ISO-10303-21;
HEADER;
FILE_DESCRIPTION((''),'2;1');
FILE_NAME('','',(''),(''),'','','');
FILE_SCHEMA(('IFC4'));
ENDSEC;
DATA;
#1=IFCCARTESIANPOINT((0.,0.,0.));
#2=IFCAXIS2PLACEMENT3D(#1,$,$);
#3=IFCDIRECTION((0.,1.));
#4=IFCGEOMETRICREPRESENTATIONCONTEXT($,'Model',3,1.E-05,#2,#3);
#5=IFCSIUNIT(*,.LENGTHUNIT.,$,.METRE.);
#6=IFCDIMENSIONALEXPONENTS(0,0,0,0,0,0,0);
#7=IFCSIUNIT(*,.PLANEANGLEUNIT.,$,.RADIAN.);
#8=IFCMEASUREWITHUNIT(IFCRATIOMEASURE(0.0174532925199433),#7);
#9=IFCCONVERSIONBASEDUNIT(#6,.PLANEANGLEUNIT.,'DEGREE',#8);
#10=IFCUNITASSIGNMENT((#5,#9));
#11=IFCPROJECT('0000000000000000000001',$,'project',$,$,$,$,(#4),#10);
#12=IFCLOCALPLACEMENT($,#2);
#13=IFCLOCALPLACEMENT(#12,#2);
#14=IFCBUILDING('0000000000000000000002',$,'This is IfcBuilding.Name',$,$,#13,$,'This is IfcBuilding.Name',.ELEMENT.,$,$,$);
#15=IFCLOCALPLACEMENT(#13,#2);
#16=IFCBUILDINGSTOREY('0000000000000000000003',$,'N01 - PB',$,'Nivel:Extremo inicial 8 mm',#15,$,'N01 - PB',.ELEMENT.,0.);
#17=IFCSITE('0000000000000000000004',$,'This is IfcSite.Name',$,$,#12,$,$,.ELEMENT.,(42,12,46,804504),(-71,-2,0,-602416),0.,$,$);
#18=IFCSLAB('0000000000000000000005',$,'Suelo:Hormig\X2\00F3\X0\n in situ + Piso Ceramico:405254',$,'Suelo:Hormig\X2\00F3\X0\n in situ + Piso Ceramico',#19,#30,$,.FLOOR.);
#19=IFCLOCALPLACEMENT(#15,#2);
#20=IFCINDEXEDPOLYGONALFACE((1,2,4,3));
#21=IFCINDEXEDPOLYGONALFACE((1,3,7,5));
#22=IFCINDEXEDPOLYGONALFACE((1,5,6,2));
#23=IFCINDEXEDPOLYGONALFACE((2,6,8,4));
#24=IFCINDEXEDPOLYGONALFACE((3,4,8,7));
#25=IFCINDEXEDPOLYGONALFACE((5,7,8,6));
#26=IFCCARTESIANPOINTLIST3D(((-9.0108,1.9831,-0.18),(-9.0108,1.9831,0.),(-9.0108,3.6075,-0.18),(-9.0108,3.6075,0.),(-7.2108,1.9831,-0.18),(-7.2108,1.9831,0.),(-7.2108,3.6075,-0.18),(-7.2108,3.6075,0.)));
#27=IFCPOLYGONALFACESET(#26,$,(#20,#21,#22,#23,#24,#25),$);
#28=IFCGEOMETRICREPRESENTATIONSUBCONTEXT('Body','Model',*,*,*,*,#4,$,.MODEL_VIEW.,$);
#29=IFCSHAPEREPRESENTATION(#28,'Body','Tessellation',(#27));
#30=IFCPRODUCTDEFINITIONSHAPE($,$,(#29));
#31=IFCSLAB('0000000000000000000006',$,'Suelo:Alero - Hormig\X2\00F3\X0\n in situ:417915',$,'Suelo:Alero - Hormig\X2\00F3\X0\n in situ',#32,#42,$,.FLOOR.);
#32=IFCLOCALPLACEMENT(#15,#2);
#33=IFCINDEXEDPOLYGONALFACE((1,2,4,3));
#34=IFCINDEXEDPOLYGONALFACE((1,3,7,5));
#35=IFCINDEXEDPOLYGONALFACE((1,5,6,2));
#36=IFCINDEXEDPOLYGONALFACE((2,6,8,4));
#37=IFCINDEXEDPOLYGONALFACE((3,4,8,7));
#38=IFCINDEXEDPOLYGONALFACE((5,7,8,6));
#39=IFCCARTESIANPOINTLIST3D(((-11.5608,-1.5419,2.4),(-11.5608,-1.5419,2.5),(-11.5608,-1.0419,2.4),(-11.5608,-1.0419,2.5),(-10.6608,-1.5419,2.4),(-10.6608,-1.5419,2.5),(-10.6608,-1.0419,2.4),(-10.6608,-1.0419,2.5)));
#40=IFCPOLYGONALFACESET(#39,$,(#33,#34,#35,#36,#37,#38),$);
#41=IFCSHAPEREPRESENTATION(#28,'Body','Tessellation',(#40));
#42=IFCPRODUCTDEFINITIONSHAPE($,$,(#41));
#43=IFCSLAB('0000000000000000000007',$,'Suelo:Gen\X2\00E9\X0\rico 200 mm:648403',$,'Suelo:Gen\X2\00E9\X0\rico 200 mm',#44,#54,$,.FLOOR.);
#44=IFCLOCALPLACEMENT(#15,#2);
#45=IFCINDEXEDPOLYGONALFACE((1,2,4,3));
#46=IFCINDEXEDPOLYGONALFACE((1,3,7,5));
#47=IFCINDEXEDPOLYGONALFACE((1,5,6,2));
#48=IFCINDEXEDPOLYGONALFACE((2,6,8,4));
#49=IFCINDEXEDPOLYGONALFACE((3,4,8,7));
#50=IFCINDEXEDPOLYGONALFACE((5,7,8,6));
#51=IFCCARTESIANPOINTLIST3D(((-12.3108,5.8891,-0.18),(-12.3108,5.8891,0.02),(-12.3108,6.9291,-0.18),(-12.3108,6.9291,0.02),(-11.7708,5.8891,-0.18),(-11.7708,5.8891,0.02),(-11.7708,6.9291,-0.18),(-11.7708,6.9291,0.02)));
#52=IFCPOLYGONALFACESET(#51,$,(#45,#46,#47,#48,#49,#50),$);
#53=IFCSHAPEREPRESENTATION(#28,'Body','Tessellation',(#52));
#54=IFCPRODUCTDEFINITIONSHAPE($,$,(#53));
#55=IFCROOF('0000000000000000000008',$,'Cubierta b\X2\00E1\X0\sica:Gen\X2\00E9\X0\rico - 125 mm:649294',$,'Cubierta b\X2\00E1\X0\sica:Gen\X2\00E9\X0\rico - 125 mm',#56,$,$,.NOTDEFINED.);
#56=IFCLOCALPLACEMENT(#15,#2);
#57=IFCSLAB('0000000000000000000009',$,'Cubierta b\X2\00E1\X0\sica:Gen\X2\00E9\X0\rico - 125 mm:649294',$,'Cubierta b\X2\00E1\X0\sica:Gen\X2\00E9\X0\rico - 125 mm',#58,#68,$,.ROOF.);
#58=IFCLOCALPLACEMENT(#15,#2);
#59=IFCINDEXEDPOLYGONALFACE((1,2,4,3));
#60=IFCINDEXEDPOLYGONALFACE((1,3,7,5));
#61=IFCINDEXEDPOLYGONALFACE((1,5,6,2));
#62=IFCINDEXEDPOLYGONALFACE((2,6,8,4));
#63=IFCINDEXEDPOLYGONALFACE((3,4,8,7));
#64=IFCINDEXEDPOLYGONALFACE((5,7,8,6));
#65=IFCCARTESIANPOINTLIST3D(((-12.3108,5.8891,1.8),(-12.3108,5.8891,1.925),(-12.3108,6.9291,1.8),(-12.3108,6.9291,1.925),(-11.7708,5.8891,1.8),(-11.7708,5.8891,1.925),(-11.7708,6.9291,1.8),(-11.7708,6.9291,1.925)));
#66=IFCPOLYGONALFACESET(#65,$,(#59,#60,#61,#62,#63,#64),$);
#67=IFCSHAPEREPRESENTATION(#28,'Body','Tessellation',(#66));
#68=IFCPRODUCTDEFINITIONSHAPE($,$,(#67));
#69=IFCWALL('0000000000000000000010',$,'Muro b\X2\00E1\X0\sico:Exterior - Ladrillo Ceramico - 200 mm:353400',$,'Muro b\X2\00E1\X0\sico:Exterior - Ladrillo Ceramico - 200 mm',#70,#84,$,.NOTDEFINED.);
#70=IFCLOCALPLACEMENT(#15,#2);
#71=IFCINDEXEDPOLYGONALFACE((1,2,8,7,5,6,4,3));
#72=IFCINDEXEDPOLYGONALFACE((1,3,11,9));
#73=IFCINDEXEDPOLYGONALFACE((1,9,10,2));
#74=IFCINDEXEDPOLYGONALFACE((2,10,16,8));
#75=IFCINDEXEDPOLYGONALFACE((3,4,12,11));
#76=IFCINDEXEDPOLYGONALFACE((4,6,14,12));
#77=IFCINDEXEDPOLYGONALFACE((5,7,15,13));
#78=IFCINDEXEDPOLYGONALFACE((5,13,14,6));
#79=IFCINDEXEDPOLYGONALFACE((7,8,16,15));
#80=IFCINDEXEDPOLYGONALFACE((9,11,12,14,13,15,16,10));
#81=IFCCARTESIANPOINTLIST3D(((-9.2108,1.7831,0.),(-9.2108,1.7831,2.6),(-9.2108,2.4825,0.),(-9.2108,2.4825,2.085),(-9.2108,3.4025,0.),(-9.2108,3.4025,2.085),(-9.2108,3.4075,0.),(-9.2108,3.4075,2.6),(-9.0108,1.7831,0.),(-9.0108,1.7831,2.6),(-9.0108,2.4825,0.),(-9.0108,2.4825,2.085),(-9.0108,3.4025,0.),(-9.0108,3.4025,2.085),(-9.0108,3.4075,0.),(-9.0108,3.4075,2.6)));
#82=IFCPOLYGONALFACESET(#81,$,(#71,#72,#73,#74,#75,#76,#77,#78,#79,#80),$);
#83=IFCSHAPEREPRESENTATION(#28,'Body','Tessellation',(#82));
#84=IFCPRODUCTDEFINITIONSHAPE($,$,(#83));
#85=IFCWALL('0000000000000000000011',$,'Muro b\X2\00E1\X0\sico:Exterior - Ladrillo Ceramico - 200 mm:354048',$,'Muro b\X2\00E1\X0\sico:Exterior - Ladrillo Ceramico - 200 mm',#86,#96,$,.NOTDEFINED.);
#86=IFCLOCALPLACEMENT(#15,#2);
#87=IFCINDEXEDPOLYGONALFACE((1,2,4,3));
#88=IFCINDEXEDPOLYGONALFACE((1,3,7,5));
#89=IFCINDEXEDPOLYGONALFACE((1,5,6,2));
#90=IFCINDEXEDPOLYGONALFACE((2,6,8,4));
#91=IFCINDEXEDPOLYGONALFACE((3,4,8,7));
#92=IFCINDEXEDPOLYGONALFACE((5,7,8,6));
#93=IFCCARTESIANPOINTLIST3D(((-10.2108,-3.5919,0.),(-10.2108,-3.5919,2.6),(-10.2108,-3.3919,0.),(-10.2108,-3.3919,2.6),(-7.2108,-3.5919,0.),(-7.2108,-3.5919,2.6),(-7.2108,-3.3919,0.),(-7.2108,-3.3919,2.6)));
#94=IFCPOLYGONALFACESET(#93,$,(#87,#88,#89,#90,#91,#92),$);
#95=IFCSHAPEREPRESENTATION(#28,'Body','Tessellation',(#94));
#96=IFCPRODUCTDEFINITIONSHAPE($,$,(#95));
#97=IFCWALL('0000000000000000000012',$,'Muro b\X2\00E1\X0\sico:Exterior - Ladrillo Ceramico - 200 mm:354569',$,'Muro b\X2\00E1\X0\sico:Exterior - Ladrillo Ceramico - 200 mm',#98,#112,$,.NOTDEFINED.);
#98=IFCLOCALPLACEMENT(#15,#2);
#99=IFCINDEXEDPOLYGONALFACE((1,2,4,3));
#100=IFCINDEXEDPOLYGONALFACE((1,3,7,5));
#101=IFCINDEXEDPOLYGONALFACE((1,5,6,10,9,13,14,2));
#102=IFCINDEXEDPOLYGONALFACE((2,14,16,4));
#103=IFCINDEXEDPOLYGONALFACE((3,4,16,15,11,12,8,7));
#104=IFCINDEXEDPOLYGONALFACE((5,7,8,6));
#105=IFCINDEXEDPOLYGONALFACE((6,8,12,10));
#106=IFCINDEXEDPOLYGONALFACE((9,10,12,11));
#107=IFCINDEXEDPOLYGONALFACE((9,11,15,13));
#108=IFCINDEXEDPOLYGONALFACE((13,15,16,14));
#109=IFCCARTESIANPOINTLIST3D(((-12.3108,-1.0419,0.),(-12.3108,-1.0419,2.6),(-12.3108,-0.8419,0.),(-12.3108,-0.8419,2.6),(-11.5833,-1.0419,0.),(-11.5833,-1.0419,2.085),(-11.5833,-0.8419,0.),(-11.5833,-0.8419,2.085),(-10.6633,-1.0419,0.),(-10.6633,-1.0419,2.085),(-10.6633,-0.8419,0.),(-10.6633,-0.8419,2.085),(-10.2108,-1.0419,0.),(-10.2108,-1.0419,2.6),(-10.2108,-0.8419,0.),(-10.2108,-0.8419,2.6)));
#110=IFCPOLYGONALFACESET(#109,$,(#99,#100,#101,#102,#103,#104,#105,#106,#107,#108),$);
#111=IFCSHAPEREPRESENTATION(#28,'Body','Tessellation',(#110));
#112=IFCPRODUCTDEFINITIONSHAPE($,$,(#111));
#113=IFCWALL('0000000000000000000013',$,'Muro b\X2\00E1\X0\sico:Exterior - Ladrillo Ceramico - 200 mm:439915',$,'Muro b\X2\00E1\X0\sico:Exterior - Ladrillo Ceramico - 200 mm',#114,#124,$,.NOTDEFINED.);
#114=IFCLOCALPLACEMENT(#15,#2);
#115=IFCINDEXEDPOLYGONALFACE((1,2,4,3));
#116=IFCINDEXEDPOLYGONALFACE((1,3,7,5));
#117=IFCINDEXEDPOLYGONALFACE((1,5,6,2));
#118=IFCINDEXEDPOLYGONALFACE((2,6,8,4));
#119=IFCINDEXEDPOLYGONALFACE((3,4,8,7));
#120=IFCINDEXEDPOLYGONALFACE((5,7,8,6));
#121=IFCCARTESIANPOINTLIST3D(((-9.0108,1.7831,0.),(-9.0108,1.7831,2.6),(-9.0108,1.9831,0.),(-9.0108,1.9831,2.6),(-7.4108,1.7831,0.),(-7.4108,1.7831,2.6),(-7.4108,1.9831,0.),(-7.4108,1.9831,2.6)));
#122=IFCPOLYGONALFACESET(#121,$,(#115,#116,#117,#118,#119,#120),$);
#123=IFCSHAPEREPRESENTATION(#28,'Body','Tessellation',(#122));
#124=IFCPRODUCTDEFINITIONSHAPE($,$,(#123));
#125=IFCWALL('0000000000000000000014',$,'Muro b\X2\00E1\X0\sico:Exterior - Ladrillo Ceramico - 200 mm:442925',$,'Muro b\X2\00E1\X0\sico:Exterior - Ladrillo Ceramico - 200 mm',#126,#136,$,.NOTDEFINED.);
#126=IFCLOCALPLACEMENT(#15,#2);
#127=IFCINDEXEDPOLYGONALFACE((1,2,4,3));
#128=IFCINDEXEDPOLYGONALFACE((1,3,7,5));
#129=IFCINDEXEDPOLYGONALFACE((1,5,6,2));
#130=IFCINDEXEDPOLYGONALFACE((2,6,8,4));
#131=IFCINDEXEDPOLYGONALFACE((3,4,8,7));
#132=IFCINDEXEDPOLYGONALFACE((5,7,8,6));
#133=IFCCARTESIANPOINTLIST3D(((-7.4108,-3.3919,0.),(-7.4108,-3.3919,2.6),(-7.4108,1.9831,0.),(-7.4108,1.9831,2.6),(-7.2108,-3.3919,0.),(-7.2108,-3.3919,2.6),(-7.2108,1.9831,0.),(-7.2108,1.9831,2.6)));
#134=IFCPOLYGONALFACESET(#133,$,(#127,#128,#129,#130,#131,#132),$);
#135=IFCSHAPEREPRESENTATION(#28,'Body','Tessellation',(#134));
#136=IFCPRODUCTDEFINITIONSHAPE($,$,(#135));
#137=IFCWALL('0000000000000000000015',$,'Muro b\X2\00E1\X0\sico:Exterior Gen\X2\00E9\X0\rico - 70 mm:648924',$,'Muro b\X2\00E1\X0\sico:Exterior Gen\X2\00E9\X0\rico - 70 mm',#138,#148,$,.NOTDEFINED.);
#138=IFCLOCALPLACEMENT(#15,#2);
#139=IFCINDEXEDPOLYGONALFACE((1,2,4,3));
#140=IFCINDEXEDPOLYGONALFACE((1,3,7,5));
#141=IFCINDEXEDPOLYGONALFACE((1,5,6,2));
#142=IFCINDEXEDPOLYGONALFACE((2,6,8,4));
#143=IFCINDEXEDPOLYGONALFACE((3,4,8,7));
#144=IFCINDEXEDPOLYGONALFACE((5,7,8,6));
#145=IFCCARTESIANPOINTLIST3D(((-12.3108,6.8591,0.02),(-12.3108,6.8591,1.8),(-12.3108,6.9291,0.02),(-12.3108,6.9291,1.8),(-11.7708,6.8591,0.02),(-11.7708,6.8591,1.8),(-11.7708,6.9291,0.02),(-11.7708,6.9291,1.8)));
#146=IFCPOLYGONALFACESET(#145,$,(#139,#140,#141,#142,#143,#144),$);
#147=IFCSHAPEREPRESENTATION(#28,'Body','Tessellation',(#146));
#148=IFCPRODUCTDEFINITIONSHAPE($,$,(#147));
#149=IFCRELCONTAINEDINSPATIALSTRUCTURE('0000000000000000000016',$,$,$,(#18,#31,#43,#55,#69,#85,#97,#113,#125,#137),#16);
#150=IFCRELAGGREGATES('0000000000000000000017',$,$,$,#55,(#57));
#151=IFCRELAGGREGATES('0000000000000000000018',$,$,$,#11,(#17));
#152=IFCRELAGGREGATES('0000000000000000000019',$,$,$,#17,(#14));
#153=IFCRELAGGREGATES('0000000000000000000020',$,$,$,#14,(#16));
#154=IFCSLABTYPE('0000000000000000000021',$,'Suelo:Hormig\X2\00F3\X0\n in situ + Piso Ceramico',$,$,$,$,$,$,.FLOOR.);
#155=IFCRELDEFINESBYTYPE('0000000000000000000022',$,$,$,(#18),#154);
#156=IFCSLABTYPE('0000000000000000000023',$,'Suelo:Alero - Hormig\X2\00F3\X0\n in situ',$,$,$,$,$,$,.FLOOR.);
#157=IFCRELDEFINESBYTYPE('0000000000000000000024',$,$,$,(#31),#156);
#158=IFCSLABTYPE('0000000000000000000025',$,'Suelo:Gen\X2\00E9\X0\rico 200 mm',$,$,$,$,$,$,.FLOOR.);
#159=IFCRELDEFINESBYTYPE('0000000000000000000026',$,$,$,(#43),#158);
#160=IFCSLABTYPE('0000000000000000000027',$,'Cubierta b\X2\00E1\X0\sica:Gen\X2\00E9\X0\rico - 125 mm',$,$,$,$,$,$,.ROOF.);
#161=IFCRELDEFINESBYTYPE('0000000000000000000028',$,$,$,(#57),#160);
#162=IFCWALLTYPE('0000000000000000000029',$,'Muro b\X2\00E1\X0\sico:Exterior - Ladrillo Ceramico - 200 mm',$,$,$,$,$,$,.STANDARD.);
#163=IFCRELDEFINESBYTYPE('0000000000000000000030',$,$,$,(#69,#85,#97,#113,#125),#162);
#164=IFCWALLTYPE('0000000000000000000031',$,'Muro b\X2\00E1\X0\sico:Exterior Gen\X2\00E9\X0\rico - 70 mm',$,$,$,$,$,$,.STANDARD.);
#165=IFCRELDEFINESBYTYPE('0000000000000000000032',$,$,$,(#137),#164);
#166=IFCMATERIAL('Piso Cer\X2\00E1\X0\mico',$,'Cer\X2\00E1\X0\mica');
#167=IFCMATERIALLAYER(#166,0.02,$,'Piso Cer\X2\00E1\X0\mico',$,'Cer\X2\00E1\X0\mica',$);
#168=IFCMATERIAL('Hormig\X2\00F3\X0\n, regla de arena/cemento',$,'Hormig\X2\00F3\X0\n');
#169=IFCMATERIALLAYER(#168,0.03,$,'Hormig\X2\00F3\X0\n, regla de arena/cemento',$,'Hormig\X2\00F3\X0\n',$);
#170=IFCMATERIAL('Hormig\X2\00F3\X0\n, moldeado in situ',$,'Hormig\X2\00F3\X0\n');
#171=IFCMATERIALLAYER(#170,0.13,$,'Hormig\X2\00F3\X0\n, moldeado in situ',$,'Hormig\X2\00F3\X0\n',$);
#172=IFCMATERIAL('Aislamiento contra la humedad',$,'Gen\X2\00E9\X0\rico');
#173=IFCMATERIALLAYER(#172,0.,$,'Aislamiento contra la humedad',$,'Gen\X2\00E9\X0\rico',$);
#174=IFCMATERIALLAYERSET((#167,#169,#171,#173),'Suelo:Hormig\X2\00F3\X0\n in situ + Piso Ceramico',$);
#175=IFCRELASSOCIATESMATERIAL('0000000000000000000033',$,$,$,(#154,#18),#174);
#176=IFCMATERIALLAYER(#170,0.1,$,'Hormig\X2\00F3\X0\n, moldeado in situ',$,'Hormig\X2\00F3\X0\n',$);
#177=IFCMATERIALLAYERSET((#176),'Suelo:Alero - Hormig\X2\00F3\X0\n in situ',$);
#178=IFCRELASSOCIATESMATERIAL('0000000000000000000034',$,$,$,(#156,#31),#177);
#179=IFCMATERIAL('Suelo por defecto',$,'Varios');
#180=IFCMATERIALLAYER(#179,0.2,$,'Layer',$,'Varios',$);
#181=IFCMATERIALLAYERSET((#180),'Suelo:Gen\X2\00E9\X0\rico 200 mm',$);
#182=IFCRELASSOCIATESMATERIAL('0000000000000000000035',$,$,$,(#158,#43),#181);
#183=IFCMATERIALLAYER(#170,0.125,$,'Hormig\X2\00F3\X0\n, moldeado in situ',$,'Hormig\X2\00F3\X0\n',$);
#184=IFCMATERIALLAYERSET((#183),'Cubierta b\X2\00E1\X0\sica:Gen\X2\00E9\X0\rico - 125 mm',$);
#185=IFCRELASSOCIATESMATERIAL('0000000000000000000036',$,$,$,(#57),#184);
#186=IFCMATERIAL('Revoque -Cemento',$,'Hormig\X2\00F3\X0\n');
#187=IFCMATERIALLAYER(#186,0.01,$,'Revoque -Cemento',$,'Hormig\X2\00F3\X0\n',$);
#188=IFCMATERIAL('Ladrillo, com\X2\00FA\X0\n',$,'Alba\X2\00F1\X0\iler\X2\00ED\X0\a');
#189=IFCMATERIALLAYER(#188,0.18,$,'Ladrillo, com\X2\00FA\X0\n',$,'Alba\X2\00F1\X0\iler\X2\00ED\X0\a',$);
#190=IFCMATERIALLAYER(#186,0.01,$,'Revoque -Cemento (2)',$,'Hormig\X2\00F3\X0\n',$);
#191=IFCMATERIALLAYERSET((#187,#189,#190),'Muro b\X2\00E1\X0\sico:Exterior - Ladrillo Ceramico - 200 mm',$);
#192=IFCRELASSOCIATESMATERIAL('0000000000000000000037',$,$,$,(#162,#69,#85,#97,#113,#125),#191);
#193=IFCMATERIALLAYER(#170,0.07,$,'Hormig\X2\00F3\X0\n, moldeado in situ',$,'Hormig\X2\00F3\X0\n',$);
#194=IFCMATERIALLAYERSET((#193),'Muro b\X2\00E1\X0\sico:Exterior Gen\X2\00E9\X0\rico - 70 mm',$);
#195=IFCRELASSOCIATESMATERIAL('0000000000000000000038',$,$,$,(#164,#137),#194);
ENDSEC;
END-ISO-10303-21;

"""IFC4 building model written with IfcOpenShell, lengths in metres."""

from ifc_helpers import new_model, entity, si_unit, converted_unit, direction, frame, frame_2d, origin, origin_2d_with_axis, place, context, subcontext, project, spatial, polyline, rectangle, extrude, clip, bounded_halfspace, material, layer, layer_set, layer_usage, type_object, element, aggregate, save


model = new_model("IFC4")

# Units and contexts
model_context = context("Model", 3, precision=1e-05, world=origin(), true_north=direction((0.0, 1.0)))
body_context = subcontext(model_context, "Body", "Model", "MODEL_VIEW")
ifc_project = project(units=[si_unit("LENGTHUNIT", "METRE"), converted_unit("PLANEANGLEUNIT", "DEGREE", entity("IfcRatioMeasure", 0.0174532925199433), si_unit("PLANEANGLEUNIT", "RADIAN"), dimensions=[0, 0, 0, 0, 0, 0, 0])], contexts=[model_context])

# Site, building, storey
site_placement = place(None, origin())
site = spatial("IfcSite", under=ifc_project, at=site_placement, Name="This is IfcSite.Name", CompositionType="ELEMENT", RefLatitude=(42, 12, 46, 804504), RefLongitude=(-71, -2, 0, -602416), RefElevation=0.0)
building_placement = place(site_placement, origin())
building = spatial("IfcBuilding", under=site, at=building_placement, Name="This is IfcBuilding.Name", LongName="This is IfcBuilding.Name", CompositionType="ELEMENT")
storey_placement = place(building_placement, origin())
storey = spatial("IfcBuildingStorey", under=building, at=storey_placement, Name="N01 - PB", ObjectType="Nivel:Extremo inicial 8 mm", LongName="N01 - PB", CompositionType="ELEMENT", Elevation=0.0)

# Slabs
ifc_material_1 = material(Name="Piso Cerámico", Category="Cerámica")
ifc_layer_1 = layer(ifc_material_1, 0.02, Name="Piso Cerámico", Category="Cerámica")
ifc_material_2 = material(Name="Hormigón, regla de arena/cemento", Category="Hormigón")
ifc_layer_2 = layer(ifc_material_2, 0.03, Name="Hormigón, regla de arena/cemento", Category="Hormigón")
ifc_material_3 = material(Name="Hormigón, moldeado in situ", Category="Hormigón")
ifc_layer_3 = layer(ifc_material_3, 0.13, Name="Hormigón, moldeado in situ", Category="Hormigón")
ifc_material_4 = material(Name="Aislamiento contra la humedad", Category="Genérico")
ifc_layer_4 = layer(ifc_material_4, 0.0, Name="Aislamiento contra la humedad", Category="Genérico")
ifc_layer_set_1 = layer_set([ifc_layer_1, ifc_layer_2, ifc_layer_3, ifc_layer_4], Name="Suelo:Hormigón in situ + Piso Ceramico")
ifc_layer_usage_1 = layer_usage(ifc_layer_set_1, "AXIS3", "POSITIVE", 0.0)
slab_type_1 = type_object("IfcSlabType", Name="Suelo:Hormigón in situ + Piso Ceramico", PredefinedType="FLOOR", material=ifc_layer_set_1)
slab_1_placement = place(storey_placement, origin())
element("IfcSlab", 1, at=slab_1_placement, inside=storey, type_object=slab_type_1, material=ifc_layer_usage_1, Name="Suelo:Hormigón in situ + Piso Ceramico:405254", ObjectType="Suelo:Hormigón in situ + Piso Ceramico", PredefinedType="FLOOR", context=body_context, shape_type="SweptSolid", body=[
    extrude(rectangle(XDim=1.6243, YDim=1.8, at=origin_2d_with_axis()), frame((-8.1108, 2.7953, 0.0), z_axis=(0.0, 0.0, -1.0), x_axis=(0.0, 1.0, 0.0)), (0.0, 0.0, 1.0), 0.18),
])
ifc_layer_5 = layer(ifc_material_3, 0.1, Name="Hormigón, moldeado in situ", Category="Hormigón")
ifc_layer_set_2 = layer_set([ifc_layer_5], Name="Suelo:Alero - Hormigón in situ")
ifc_layer_usage_2 = layer_usage(ifc_layer_set_2, "AXIS3", "POSITIVE", 0.0)
slab_type_2 = type_object("IfcSlabType", Name="Suelo:Alero - Hormigón in situ", PredefinedType="FLOOR", material=ifc_layer_set_2)
slab_2_placement = place(storey_placement, origin())
element("IfcSlab", 2, at=slab_2_placement, inside=storey, type_object=slab_type_2, material=ifc_layer_usage_2, Name="Suelo:Alero - Hormigón in situ:417915", ObjectType="Suelo:Alero - Hormigón in situ", PredefinedType="FLOOR", context=body_context, shape_type="SweptSolid", body=[
    extrude(rectangle(XDim=0.5, YDim=0.9, at=frame_2d((0.0, 0.0), x_axis=(1.0, 0.0))), frame((-11.1108, -1.2919, 2.5), z_axis=(0.0, 0.0, -1.0), x_axis=(0.0, 1.0, 0.0)), (0.0, 0.0, 1.0), 0.1),
])
ifc_material_5 = material(Name="Suelo por defecto", Category="Varios")
ifc_layer_6 = layer(ifc_material_5, 0.2, Name="Layer", Category="Varios")
ifc_layer_set_3 = layer_set([ifc_layer_6], Name="Suelo:Genérico 200 mm")
ifc_layer_usage_3 = layer_usage(ifc_layer_set_3, "AXIS3", "POSITIVE", 0.0)
slab_type_3 = type_object("IfcSlabType", Name="Suelo:Genérico 200 mm", PredefinedType="FLOOR", material=ifc_layer_set_3)
slab_3_placement = place(storey_placement, origin())
element("IfcSlab", 3, at=slab_3_placement, inside=storey, type_object=slab_type_3, material=ifc_layer_usage_3, Name="Suelo:Genérico 200 mm:648403", ObjectType="Suelo:Genérico 200 mm", PredefinedType="FLOOR", context=body_context, shape_type="SweptSolid", body=[
    extrude(rectangle(XDim=1.04, YDim=0.54, at=origin_2d_with_axis()), frame((-12.0408, 6.4091, 0.02), z_axis=(0.0, 0.0, -1.0), x_axis=(0.0, 1.0, 0.0)), (0.0, 0.0, 1.0), 0.2),
])

# Roof, slab
roof_placement = place(storey_placement, frame((-12.3108, 5.8891, 1.8)))
roof = element("IfcRoof", 4, at=roof_placement, inside=storey, Name="Cubierta básica:Genérico - 125 mm:649294", ObjectType="Cubierta básica:Genérico - 125 mm", PredefinedType="NOTDEFINED")
ifc_layer_7 = layer(ifc_material_3, 0.125, Name="Hormigón, moldeado in situ", Category="Hormigón")
ifc_layer_set_4 = layer_set([ifc_layer_7], Name="Cubierta básica:Genérico - 125 mm")
slab_type_4 = type_object("IfcSlabType", Name="Cubierta básica:Genérico - 125 mm", PredefinedType="ROOF")
slab_4_placement = place(roof_placement, origin())
slab_4 = element("IfcSlab", 5, at=slab_4_placement, type_object=slab_type_4, material=ifc_layer_set_4, Name="Cubierta básica:Genérico - 125 mm:649294", ObjectType="Cubierta básica:Genérico - 125 mm", PredefinedType="ROOF", context=body_context, shape_type="SweptSolid", body=[
    extrude(rectangle(XDim=0.54, YDim=1.04, at=origin_2d_with_axis()), frame((0.27, 0.52, 0.0)), (0.0, 0.0, 1.0), 0.125),
])
aggregate(roof, [slab_4])

# Shared definitions
ifc_material_6 = material(Name="Revoque -Cemento", Category="Hormigón")
ifc_layer_8 = layer(ifc_material_6, 0.01, Name="Revoque -Cemento", Category="Hormigón")
ifc_material_7 = material(Name="Ladrillo, común", Category="Albañilería")
ifc_layer_9 = layer(ifc_material_7, 0.18, Name="Ladrillo, común", Category="Albañilería")
ifc_layer_10 = layer(ifc_material_6, 0.01, Name="Revoque -Cemento (2)", Category="Hormigón")
ifc_layer_set_5 = layer_set([ifc_layer_8, ifc_layer_9, ifc_layer_10], Name="Muro básico:Exterior - Ladrillo Ceramico - 200 mm")
wall_type_1 = type_object("IfcWallType", Name="Muro básico:Exterior - Ladrillo Ceramico - 200 mm", PredefinedType="STANDARD", material=ifc_layer_set_5)

# Wall, opening
ifc_layer_usage_4 = layer_usage(ifc_layer_set_5, "AXIS2", "NEGATIVE", 0.1)
wall_1_placement = place(storey_placement, frame((-9.1108, 3.4075, 0.0), z_axis=(0.0, 0.0, 1.0), x_axis=(0.0, -1.0, 0.0)))
wall_1 = element("IfcWall", 6, at=wall_1_placement, inside=storey, type_object=wall_type_1, material=ifc_layer_usage_4, Name="Muro básico:Exterior - Ladrillo Ceramico - 200 mm:353400", ObjectType="Muro básico:Exterior - Ladrillo Ceramico - 200 mm", PredefinedType="NOTDEFINED", context=body_context, shape_type="Clipping", body=[
    clip(extrude(rectangle(XDim=1.6243, YDim=0.2, at=frame_2d((0.8122, 0.0), x_axis=(-1.0, 0.0))), origin(), (0.0, 0.0, 1.0), 2.6), bounded_halfspace(frame((0.0, 0.0, 2.6), z_axis=(0.0, 0.0, -1.0), x_axis=(1.0, 0.0, 0.0)), True, frame((0.0, 0.0, 2.6)), polyline([(0.0, 0.0), (0.0, -0.1), (1.6243, -0.1), (1.6243, 0.0), (1.6243, 0.1), (1.5244, 0.1), (1.5244, 0.0), (0.0, 0.0)]))),
])
opening_1_placement = place(wall_1_placement, frame((0.925, -0.1, 0.0), z_axis=(0.0, 0.0, 1.0), x_axis=(0.0, 1.0, 0.0)))
element("IfcOpeningElement", 7, at=opening_1_placement, cuts=wall_1, PredefinedType="OPENING", context=body_context, shape_type="SweptSolid", body=[
    extrude(rectangle(XDim=2.085, YDim=0.92, at=frame_2d((0.0, 0.0), x_axis=(0.0, 1.0))), frame((0.0, 0.46, 1.0425), z_axis=(1.0, 0.0, 0.0), x_axis=(0.0, -1.0, 0.0)), (0.0, 0.0, 1.0), 0.2),
])

# Wall
ifc_layer_usage_5 = layer_usage(ifc_layer_set_5, "AXIS2", "NEGATIVE", 0.1)
wall_2_placement = place(storey_placement, frame((-7.2108, -3.4919, 0.0), z_axis=(0.0, 0.0, 1.0), x_axis=(-1.0, 0.0, 0.0)))
element("IfcWall", 8, at=wall_2_placement, inside=storey, type_object=wall_type_1, material=ifc_layer_usage_5, Name="Muro básico:Exterior - Ladrillo Ceramico - 200 mm:354048", ObjectType="Muro básico:Exterior - Ladrillo Ceramico - 200 mm", PredefinedType="NOTDEFINED", context=body_context, shape_type="Clipping", body=[
    clip(extrude(rectangle(XDim=3.0, YDim=0.2, at=frame_2d((1.5, 0.0), x_axis=(-1.0, 0.0))), origin(), (0.0, 0.0, 1.0), 2.6), bounded_halfspace(frame((0.1, -0.1, 2.6), z_axis=(0.0, 0.0, -1.0), x_axis=(0.0, 1.0, 0.0)), True, frame((0.1, -0.1, 2.6)), polyline([(0.0, 0.0), (0.1, 0.0), (2.7, 0.0), (2.9, 0.0), (2.9, 0.2), (0.0, 0.2), (0.0, 0.0)]))),
])

# Wall, opening
ifc_layer_usage_6 = layer_usage(ifc_layer_set_5, "AXIS2", "NEGATIVE", 0.1)
wall_3_placement = place(storey_placement, frame((-10.2108, -0.9419, 0.0), z_axis=(0.0, 0.0, 1.0), x_axis=(-1.0, 0.0, 0.0)))
wall_3 = element("IfcWall", 9, at=wall_3_placement, inside=storey, type_object=wall_type_1, material=ifc_layer_usage_6, Name="Muro básico:Exterior - Ladrillo Ceramico - 200 mm:354569", ObjectType="Muro básico:Exterior - Ladrillo Ceramico - 200 mm", PredefinedType="NOTDEFINED", context=body_context, shape_type="Clipping", body=[
    clip(extrude(rectangle(XDim=2.1, YDim=0.2, at=frame_2d((1.05, 0.0), x_axis=(-1.0, 0.0))), origin(), (0.0, 0.0, 1.0), 2.6), bounded_halfspace(frame((0.0, -0.1, 2.6), z_axis=(0.0, 0.0, -1.0), x_axis=(0.0, 1.0, 0.0)), True, frame((0.0, -0.1, 2.6)), polyline([(0.0, 0.0), (0.35, 0.0), (1.9, 0.0), (2.0, 0.0), (2.0, 0.1001), (0.35, 0.1001), (0.35, 0.2), (0.0, 0.2), (0.0, 0.0)]))),
])
opening_2_placement = place(wall_3_placement, frame((1.3725, 0.1, 0.0), z_axis=(0.0, 0.0, 1.0), x_axis=(-1.0, 0.0, 0.0)))
element("IfcOpeningElement", 10, at=opening_2_placement, cuts=wall_3, PredefinedType="OPENING", context=body_context, shape_type="SweptSolid", body=[
    extrude(rectangle(XDim=2.085, YDim=0.92, at=origin_2d_with_axis()), frame((0.46, 0.2, 1.0425), z_axis=(0.0, -1.0, 0.0), x_axis=(0.0, 0.0, -1.0)), (0.0, 0.0, 1.0), 0.2),
])

# Walls
ifc_layer_usage_7 = layer_usage(ifc_layer_set_5, "AXIS2", "NEGATIVE", 0.1)
wall_4_placement = place(storey_placement, frame((-9.0108, 1.8831, 0.0)))
element("IfcWall", 11, at=wall_4_placement, inside=storey, type_object=wall_type_1, material=ifc_layer_usage_7, Name="Muro básico:Exterior - Ladrillo Ceramico - 200 mm:439915", ObjectType="Muro básico:Exterior - Ladrillo Ceramico - 200 mm", PredefinedType="NOTDEFINED", context=body_context, shape_type="Clipping", body=[
    clip(extrude(rectangle(XDim=1.6, YDim=0.2, at=frame_2d((0.8, 0.0), x_axis=(-1.0, 0.0))), origin(), (0.0, 0.0, 1.0), 2.6), bounded_halfspace(frame((0.0, -0.1, 2.6), z_axis=(0.0, 0.0, -1.0), x_axis=(0.0, 1.0, 0.0)), True, frame((0.0, -0.1, 2.6)), polyline([(0.0, 0.0), (1.6, 0.0), (1.6, 0.2), (0.0, 0.2), (0.0, 0.0)]))),
])
ifc_layer_usage_8 = layer_usage(ifc_layer_set_5, "AXIS2", "NEGATIVE", 0.1)
wall_5_placement = place(storey_placement, frame((-7.3108, 1.9831, 0.0), z_axis=(0.0, 0.0, 1.0), x_axis=(0.0, -1.0, 0.0)))
element("IfcWall", 12, at=wall_5_placement, inside=storey, type_object=wall_type_1, material=ifc_layer_usage_8, Name="Muro básico:Exterior - Ladrillo Ceramico - 200 mm:442925", ObjectType="Muro básico:Exterior - Ladrillo Ceramico - 200 mm", PredefinedType="NOTDEFINED", context=body_context, shape_type="Clipping", body=[
    clip(extrude(rectangle(XDim=5.3751, YDim=0.2, at=frame_2d((2.6875, 0.0), x_axis=(-1.0, 0.0))), origin(), (0.0, 0.0, 1.0), 2.6), bounded_halfspace(frame((2.3251, -0.1, 2.6), z_axis=(0.0, 0.0, -1.0), x_axis=(1.0, 0.0, 0.0)), True, frame((2.3251, -0.1, 2.6)), polyline([(0.0, 0.0), (3.05, 0.0), (3.05, 0.1), (0.0, 0.1), (0.0, 0.0)]))),
])
ifc_layer_11 = layer(ifc_material_3, 0.07, Name="Hormigón, moldeado in situ", Category="Hormigón")
ifc_layer_set_6 = layer_set([ifc_layer_11], Name="Muro básico:Exterior Genérico - 70 mm")
ifc_layer_usage_9 = layer_usage(ifc_layer_set_6, "AXIS2", "POSITIVE", -0.035)
wall_type_2 = type_object("IfcWallType", Name="Muro básico:Exterior Genérico - 70 mm", PredefinedType="STANDARD", material=ifc_layer_set_6)
wall_6_placement = place(storey_placement, frame((-11.7708, 6.8941, 0.02), z_axis=(0.0, 0.0, 1.0), x_axis=(-1.0, 0.0, 0.0)))
element("IfcWall", 13, at=wall_6_placement, inside=storey, type_object=wall_type_2, material=ifc_layer_usage_9, Name="Muro básico:Exterior Genérico - 70 mm:648924", ObjectType="Muro básico:Exterior Genérico - 70 mm", PredefinedType="NOTDEFINED", context=body_context, shape_type="Clipping", body=[
    clip(extrude(rectangle(XDim=0.54, YDim=0.07, at=frame_2d((0.27, 0.0), x_axis=(-1.0, 0.0))), origin(), (0.0, 0.0, 1.0), 1.78), bounded_halfspace(frame((0.0, -0.035, 1.78), z_axis=(0.0, 0.0, 1.0), x_axis=(-1.0, 0.0, 0.0)), False, frame((0.0, -0.035, 1.78)), polyline([(0.0, 0.0), (0.54, 0.0), (0.54, 0.07), (0.47, 0.07), (0.0, 0.07), (0.0, 0.0)]))),
])

save(model, "model.ifc")
